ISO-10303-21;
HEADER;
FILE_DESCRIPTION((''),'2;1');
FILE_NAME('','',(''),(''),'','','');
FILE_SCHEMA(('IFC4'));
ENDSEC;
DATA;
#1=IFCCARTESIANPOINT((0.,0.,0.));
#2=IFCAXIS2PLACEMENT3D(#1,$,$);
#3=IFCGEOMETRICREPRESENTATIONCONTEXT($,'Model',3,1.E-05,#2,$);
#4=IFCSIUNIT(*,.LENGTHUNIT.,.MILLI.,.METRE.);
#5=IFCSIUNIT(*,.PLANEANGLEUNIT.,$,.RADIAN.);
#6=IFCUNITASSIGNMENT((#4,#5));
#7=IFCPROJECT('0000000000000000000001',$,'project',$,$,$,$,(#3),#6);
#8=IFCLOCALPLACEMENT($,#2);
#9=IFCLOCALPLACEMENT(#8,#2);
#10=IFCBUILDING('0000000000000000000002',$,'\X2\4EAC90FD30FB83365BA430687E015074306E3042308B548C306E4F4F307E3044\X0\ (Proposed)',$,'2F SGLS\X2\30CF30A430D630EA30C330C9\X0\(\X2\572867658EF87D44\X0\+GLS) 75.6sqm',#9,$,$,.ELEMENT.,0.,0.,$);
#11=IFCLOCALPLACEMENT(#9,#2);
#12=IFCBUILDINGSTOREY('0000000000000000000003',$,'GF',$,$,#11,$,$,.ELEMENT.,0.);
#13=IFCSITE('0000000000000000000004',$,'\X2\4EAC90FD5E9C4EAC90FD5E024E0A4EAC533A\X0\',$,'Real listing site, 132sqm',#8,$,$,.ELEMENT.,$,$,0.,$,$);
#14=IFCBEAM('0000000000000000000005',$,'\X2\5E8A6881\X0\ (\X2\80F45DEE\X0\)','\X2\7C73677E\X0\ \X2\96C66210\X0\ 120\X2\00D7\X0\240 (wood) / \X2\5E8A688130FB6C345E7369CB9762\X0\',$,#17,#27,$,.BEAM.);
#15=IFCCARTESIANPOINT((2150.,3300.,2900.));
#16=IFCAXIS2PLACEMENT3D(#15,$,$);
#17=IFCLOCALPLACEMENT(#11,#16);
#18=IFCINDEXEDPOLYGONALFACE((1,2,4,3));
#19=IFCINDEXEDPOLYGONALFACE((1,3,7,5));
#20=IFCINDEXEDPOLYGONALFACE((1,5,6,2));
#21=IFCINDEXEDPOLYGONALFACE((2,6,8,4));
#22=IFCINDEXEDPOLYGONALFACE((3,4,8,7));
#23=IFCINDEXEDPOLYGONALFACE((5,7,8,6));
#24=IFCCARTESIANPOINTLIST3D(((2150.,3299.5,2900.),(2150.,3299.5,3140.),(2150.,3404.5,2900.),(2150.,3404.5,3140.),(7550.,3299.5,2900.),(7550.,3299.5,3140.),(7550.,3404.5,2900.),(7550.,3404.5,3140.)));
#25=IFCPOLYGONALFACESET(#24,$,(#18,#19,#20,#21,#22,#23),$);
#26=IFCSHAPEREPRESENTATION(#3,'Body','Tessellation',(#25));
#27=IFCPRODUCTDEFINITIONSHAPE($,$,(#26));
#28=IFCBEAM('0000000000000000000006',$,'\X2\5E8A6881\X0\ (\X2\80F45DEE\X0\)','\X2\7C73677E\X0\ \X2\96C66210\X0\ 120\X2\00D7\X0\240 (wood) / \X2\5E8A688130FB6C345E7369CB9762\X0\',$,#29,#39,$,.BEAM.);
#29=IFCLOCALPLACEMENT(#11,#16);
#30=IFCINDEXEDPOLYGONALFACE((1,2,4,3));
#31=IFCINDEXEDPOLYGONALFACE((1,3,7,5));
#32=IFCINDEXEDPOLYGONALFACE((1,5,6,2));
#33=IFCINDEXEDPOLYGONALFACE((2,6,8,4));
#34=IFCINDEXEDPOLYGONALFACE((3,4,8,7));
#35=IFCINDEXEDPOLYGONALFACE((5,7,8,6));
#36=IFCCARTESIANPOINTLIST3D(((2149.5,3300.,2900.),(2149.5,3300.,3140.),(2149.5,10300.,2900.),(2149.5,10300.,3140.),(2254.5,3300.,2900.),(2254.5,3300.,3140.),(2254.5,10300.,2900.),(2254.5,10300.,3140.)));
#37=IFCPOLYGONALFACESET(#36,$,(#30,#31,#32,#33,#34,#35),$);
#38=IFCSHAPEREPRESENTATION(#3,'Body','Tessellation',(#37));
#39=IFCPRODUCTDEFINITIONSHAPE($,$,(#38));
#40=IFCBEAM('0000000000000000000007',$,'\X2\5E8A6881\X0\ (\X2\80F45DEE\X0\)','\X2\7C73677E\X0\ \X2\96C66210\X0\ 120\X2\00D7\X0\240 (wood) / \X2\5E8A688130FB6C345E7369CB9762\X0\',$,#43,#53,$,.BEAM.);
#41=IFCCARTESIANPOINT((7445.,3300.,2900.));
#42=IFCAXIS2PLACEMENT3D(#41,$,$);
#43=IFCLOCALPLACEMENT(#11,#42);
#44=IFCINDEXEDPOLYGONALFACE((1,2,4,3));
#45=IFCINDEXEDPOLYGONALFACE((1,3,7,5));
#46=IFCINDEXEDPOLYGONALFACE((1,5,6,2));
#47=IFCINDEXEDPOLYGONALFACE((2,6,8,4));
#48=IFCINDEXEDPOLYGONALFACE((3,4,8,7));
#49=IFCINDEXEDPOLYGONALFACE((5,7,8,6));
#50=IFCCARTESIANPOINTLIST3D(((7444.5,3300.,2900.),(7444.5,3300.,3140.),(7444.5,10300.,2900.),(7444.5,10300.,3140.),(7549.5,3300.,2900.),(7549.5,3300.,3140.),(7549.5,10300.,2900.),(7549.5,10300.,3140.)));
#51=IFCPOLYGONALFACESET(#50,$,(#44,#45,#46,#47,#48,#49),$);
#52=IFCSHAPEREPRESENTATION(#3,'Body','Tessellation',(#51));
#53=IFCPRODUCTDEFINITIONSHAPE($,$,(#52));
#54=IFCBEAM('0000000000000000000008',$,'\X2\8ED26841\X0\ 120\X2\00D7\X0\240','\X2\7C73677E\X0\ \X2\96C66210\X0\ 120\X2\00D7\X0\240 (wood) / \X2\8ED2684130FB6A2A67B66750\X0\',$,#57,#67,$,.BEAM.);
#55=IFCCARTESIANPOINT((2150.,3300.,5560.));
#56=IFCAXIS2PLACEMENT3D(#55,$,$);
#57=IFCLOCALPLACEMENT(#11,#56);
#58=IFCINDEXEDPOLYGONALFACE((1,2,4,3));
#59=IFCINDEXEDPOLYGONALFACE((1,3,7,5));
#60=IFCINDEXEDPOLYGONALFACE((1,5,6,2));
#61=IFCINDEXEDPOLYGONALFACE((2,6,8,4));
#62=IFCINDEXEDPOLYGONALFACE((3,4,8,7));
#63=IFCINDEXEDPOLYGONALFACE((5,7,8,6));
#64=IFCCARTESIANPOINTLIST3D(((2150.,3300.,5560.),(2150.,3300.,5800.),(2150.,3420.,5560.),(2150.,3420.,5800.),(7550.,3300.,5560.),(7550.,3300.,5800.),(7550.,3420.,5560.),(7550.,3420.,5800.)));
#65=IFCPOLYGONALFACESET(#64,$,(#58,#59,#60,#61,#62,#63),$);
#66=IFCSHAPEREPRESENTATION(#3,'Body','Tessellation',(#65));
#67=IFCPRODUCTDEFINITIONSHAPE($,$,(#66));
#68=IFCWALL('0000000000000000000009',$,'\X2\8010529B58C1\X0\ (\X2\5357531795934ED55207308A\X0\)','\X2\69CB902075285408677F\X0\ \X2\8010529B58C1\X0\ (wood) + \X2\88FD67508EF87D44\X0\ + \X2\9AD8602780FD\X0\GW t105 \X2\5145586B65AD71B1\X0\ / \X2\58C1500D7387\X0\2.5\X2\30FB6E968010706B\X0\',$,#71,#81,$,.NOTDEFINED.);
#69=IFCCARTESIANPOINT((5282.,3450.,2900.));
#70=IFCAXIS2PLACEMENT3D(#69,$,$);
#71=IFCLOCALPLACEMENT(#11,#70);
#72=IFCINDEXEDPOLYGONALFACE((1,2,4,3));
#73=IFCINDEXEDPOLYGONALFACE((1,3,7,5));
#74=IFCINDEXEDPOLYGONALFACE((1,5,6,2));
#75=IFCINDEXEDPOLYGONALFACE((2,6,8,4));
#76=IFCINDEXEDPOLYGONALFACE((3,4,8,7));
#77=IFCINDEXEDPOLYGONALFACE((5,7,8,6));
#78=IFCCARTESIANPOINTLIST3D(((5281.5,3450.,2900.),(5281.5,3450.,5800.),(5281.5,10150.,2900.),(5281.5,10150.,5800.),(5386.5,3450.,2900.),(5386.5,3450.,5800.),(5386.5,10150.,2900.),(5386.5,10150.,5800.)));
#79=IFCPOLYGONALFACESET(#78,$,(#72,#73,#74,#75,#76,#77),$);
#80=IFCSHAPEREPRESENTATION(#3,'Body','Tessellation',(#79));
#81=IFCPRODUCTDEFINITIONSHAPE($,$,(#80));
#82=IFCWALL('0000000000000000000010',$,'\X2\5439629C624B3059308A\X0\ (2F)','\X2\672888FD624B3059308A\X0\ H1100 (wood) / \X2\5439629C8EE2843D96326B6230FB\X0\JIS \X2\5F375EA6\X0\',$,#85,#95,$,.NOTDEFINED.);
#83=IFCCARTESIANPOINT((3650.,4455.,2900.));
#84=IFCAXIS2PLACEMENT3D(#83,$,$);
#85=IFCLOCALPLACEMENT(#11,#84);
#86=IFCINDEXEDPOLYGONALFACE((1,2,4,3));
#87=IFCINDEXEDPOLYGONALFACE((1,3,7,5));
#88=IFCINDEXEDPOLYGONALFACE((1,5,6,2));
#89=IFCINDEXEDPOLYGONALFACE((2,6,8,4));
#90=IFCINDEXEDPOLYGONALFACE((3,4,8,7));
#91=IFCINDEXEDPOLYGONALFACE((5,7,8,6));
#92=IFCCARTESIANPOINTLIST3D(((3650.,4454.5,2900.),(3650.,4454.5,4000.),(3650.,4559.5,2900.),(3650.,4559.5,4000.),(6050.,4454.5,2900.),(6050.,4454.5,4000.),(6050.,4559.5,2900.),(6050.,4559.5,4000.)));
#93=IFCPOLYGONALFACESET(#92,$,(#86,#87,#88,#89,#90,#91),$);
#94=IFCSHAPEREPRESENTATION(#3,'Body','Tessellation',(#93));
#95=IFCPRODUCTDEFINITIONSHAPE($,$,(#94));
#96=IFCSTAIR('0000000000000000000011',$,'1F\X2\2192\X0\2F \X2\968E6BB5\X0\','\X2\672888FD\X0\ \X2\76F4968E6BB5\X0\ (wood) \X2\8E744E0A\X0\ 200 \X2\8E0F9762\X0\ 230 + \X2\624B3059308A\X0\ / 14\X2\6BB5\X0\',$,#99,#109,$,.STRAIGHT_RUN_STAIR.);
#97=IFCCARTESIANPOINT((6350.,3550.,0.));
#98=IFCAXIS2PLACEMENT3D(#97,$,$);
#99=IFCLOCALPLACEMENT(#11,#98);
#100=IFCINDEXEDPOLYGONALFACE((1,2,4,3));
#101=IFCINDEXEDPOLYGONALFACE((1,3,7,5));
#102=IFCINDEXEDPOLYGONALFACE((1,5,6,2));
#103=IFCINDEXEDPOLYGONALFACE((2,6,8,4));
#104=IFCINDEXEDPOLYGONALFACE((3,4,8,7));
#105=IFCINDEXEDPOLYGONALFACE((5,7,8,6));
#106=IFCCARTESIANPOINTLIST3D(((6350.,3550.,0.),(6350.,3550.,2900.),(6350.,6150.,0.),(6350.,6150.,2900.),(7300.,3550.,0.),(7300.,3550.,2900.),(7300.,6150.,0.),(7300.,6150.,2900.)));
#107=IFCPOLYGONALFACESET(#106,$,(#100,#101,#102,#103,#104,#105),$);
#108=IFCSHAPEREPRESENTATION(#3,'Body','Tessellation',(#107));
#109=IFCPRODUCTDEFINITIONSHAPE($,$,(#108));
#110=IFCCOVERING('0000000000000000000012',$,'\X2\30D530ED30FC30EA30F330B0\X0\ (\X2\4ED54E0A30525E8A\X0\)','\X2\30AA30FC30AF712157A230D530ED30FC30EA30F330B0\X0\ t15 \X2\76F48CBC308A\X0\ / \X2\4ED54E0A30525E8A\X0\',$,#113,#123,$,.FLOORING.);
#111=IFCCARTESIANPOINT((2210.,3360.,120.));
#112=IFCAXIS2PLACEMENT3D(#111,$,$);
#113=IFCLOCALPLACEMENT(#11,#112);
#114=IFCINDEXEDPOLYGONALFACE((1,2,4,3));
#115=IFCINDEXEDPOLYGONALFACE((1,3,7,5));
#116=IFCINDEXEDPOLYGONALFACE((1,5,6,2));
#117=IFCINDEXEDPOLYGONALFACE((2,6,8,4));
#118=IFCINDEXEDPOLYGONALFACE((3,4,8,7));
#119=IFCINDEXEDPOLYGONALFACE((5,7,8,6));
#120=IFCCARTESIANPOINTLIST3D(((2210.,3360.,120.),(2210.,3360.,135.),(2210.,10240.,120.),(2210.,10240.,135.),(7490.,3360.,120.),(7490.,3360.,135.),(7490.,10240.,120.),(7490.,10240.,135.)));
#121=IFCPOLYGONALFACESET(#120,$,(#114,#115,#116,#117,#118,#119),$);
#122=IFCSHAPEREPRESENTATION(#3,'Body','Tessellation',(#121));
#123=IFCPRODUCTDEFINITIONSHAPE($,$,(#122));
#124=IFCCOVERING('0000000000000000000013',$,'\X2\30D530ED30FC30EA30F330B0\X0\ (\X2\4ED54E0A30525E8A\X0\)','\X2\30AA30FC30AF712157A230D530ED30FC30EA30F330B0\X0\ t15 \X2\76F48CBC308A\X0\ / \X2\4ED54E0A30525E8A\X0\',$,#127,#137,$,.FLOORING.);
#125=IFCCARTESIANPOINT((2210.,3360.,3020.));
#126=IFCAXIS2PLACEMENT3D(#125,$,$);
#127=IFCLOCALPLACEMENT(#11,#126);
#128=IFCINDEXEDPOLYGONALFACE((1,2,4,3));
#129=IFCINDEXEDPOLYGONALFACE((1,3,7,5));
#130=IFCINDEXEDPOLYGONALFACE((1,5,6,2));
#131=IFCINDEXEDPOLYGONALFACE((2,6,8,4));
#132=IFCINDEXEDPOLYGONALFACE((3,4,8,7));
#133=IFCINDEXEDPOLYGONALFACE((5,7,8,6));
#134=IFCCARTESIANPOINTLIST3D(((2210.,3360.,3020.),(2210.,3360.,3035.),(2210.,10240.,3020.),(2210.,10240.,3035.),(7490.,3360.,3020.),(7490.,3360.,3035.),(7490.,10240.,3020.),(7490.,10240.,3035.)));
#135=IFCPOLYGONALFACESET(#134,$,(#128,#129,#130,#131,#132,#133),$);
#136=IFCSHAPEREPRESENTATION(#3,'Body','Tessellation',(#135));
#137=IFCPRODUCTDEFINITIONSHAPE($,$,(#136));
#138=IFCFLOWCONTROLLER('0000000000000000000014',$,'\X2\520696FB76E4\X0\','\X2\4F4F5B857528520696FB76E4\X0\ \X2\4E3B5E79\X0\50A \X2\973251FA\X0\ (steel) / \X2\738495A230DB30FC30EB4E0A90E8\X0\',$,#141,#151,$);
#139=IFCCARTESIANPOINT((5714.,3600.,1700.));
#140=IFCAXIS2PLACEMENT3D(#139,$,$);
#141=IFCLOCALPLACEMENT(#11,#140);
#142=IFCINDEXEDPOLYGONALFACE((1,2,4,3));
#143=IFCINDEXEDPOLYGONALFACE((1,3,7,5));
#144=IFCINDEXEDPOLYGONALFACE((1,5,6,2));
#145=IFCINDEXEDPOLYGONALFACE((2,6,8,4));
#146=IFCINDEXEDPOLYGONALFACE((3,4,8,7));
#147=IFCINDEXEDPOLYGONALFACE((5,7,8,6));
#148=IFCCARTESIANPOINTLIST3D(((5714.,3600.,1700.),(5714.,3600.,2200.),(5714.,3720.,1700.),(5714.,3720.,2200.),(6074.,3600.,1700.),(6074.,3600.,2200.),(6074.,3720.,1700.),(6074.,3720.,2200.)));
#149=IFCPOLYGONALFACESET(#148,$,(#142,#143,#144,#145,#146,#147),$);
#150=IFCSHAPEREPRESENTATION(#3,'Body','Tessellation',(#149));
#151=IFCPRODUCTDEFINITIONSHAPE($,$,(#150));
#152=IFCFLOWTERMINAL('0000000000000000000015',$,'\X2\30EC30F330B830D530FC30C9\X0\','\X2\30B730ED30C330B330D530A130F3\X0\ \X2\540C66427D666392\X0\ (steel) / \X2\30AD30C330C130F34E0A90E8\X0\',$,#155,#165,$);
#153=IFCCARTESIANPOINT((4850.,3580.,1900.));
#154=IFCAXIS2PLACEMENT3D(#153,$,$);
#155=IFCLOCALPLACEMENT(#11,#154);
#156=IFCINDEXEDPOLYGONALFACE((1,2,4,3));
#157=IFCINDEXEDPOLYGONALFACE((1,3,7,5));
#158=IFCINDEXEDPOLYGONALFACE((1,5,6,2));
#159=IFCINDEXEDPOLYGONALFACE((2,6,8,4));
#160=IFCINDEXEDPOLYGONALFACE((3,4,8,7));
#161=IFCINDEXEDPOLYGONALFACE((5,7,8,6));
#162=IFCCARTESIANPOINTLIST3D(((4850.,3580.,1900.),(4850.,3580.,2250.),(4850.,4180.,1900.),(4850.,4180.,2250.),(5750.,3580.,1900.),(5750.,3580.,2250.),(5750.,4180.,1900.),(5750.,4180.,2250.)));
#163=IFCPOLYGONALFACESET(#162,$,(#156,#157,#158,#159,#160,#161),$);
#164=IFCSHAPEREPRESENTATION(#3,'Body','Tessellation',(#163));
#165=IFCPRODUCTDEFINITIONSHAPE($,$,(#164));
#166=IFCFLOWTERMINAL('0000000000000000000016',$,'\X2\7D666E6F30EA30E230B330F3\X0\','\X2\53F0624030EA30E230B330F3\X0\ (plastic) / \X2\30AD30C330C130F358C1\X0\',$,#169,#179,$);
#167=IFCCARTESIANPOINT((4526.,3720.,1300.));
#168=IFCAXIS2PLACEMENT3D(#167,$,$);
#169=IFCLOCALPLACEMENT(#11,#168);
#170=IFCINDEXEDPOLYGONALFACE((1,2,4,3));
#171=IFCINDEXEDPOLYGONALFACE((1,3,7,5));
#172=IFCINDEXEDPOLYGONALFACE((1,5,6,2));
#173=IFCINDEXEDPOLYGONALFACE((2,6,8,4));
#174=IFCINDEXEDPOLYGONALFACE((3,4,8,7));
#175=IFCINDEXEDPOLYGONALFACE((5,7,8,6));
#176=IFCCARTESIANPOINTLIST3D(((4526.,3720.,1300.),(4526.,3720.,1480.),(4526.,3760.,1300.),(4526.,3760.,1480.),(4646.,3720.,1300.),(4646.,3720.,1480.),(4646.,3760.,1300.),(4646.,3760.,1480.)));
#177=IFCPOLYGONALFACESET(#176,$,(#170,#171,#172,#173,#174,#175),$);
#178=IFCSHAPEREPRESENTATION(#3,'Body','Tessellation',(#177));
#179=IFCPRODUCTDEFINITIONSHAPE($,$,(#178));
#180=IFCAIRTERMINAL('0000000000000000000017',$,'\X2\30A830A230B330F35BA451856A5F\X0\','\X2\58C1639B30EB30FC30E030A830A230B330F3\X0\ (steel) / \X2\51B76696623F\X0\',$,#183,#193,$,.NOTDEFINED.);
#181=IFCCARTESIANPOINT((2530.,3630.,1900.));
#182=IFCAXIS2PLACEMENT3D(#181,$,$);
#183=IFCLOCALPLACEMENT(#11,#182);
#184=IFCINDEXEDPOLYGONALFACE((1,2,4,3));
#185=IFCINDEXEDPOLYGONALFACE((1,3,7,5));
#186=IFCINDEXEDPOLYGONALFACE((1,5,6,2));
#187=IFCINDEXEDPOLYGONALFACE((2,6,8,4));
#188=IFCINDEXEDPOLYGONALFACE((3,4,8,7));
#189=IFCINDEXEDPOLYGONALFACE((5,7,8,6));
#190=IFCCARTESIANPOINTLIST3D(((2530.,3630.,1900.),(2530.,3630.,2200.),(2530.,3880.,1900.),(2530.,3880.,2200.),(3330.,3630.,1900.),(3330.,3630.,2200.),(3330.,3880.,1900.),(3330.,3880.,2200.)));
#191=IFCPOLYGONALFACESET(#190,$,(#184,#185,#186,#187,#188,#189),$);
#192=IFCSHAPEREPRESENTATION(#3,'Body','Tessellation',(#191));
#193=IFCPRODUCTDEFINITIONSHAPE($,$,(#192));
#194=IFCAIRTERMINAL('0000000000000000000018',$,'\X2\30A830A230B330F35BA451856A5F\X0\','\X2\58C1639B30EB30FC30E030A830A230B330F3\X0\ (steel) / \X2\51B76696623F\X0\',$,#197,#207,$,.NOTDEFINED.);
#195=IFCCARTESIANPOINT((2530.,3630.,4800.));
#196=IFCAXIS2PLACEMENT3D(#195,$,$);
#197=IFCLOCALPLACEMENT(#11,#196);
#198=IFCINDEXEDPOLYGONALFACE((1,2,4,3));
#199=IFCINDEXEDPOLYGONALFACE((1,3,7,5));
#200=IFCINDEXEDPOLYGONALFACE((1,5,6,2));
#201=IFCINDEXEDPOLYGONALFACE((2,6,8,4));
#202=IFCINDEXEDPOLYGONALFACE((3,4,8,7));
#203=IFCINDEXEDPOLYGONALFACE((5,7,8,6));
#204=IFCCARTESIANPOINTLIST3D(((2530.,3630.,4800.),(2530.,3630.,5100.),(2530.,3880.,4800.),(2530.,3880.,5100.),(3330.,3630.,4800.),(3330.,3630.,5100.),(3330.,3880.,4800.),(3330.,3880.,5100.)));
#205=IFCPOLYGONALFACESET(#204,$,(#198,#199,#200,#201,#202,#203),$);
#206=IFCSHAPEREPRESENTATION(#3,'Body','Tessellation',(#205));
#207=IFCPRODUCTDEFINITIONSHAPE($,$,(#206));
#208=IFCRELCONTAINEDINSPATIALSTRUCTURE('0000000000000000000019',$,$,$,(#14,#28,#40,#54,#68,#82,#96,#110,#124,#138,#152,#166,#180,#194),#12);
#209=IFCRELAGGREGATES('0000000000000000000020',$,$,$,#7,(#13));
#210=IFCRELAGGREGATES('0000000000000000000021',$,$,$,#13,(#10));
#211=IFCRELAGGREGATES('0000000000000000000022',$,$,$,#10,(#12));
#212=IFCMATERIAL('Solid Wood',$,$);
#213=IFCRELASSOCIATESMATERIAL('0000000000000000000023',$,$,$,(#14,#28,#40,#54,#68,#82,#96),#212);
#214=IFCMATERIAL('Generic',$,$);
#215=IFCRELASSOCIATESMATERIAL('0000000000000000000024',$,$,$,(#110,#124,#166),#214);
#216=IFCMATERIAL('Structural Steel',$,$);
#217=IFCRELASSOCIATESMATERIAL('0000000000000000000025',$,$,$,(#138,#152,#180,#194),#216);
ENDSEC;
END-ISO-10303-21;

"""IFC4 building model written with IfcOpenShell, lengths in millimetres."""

from ifc_helpers import new_model, si_unit, frame, frame_2d, origin, place, context, project, spatial, rectangle, extrude, material, element, save


model = new_model("IFC4")

# Units and contexts
model_context = context("Model", 3, precision=1e-05, world=origin())
ifc_project = project(units=[si_unit("LENGTHUNIT", "METRE", prefix="MILLI"), si_unit("PLANEANGLEUNIT", "RADIAN")], contexts=[model_context])

# Site, building, storey
site_placement = place(None, origin())
site = spatial("IfcSite", under=ifc_project, at=site_placement, Name="京都府京都市上京区", ObjectType="Real listing site, 132sqm", CompositionType="ELEMENT", RefElevation=0.0)
building_placement = place(site_placement, origin())
building = spatial("IfcBuilding", under=site, at=building_placement, Name="京都・茶室と縁側のある和の住まい (Proposed)", ObjectType="2F SGLSハイブリッド(在来軸組+GLS) 75.6sqm", CompositionType="ELEMENT", ElevationOfRefHeight=0.0, ElevationOfTerrain=0.0)
storey_placement = place(building_placement, origin())
storey = spatial("IfcBuildingStorey", under=building, at=storey_placement, Name="GF", CompositionType="ELEMENT", Elevation=0.0)

# Shared definitions
ifc_material_1 = material(Name="Solid Wood")

# Beams
beam_1_placement = place(storey_placement, frame((2150.0, 3300.0, 2900.0)))
element("IfcBeam", 1, at=beam_1_placement, inside=storey, material=ifc_material_1, Name="床梁 (胴差)", Description="米松 集成 120×240 (wood) / 床梁・水平構面", PredefinedType="BEAM", context=model_context, shape_type="SweptSolid", body=[
    extrude(rectangle(XDim=5400.0, YDim=105.0, at=frame_2d((2700.0, 52.0))), frame((2150.0, 3300.0, 2900.0)), (0.0, 0.0, 1.0), 240.0),
])
beam_2_placement = place(storey_placement, frame((2150.0, 3300.0, 2900.0)))
element("IfcBeam", 2, at=beam_2_placement, inside=storey, material=ifc_material_1, Name="床梁 (胴差)", Description="米松 集成 120×240 (wood) / 床梁・水平構面", PredefinedType="BEAM", context=model_context, shape_type="SweptSolid", body=[
    extrude(rectangle(XDim=105.0, YDim=7000.0, at=frame_2d((52.0, 3500.0))), frame((2150.0, 3300.0, 2900.0)), (0.0, 0.0, 1.0), 240.0),
])
beam_3_placement = place(storey_placement, frame((7445.0, 3300.0, 2900.0)))
element("IfcBeam", 3, at=beam_3_placement, inside=storey, material=ifc_material_1, Name="床梁 (胴差)", Description="米松 集成 120×240 (wood) / 床梁・水平構面", PredefinedType="BEAM", context=model_context, shape_type="SweptSolid", body=[
    extrude(rectangle(XDim=105.0, YDim=7000.0, at=frame_2d((52.0, 3500.0))), frame((7445.0, 3300.0, 2900.0)), (0.0, 0.0, 1.0), 240.0),
])
beam_4_placement = place(storey_placement, frame((2150.0, 3300.0, 5560.0)))
element("IfcBeam", 4, at=beam_4_placement, inside=storey, material=ifc_material_1, Name="軒桁 120×240", Description="米松 集成 120×240 (wood) / 軒桁・横架材", PredefinedType="BEAM", context=model_context, shape_type="SweptSolid", body=[
    extrude(rectangle(XDim=5400.0, YDim=120.0, at=frame_2d((2700.0, 60.0))), frame((2150.0, 3300.0, 5560.0)), (0.0, 0.0, 1.0), 240.0),
])

# Walls
wall_1_placement = place(storey_placement, frame((5282.0, 3450.0, 2900.0)))
element("IfcWall", 5, at=wall_1_placement, inside=storey, material=ifc_material_1, Name="耐力壁 (南北間仕切り)", Description="構造用合板 耐力壁 (wood) + 製材軸組 + 高性能GW t105 充填断熱 / 壁倍率2.5・準耐火", PredefinedType="NOTDEFINED", context=model_context, shape_type="SweptSolid", body=[
    extrude(rectangle(XDim=105.0, YDim=6700.0, at=frame_2d((52.0, 3350.0))), frame((5282.0, 3450.0, 2900.0)), (0.0, 0.0, 1.0), 2900.0),
])
wall_2_placement = place(storey_placement, frame((3650.0, 4455.0, 2900.0)))
element("IfcWall", 6, at=wall_2_placement, inside=storey, material=ifc_material_1, Name="吹抜手すり (2F)", Description="木製手すり H1100 (wood) / 吹抜転落防止・JIS 強度", PredefinedType="NOTDEFINED", context=model_context, shape_type="SweptSolid", body=[
    extrude(rectangle(XDim=2400.0, YDim=105.0, at=frame_2d((1200.0, 52.0))), frame((3650.0, 4455.0, 2900.0)), (0.0, 0.0, 1.0), 1100.0),
])

# Stair
stair_placement = place(storey_placement, frame((6350.0, 3550.0, 0.0)))
element("IfcStair", 7, at=stair_placement, inside=storey, material=ifc_material_1, Name="1F→2F 階段", Description="木製 直階段 (wood) 蹴上 200 踏面 230 + 手すり / 14段", PredefinedType="STRAIGHT_RUN_STAIR", context=model_context, shape_type="SweptSolid", body=[
    extrude(rectangle(XDim=950.0, YDim=2600.0, at=frame_2d((475.0, 1300.0))), frame((6350.0, 3550.0, 0.0)), (0.0, 0.0, 1.0), 2900.0),
])

# Coverings
ifc_material_2 = material(Name="Generic")
covering_1_placement = place(storey_placement, frame((2210.0, 3360.0, 120.0)))
element("IfcCovering", 8, at=covering_1_placement, inside=storey, material=ifc_material_2, Name="フローリング (仕上げ床)", Description="オーク無垢フローリング t15 直貼り / 仕上げ床", PredefinedType="FLOORING", context=model_context, shape_type="SweptSolid", body=[
    extrude(rectangle(XDim=5280.0, YDim=6880.0, at=frame_2d((2640.0, 3440.0))), frame((2210.0, 3360.0, 120.0)), (0.0, 0.0, 1.0), 15.0),
])
covering_2_placement = place(storey_placement, frame((2210.0, 3360.0, 3020.0)))
element("IfcCovering", 9, at=covering_2_placement, inside=storey, material=ifc_material_2, Name="フローリング (仕上げ床)", Description="オーク無垢フローリング t15 直貼り / 仕上げ床", PredefinedType="FLOORING", context=model_context, shape_type="SweptSolid", body=[
    extrude(rectangle(XDim=5280.0, YDim=6880.0, at=frame_2d((2640.0, 3440.0))), frame((2210.0, 3360.0, 3020.0)), (0.0, 0.0, 1.0), 15.0),
])

# Flow controller
ifc_material_3 = material(Name="Structural Steel")
flow_controller_placement = place(storey_placement, frame((5714.0, 3600.0, 1700.0)))
element("IfcFlowController", 10, at=flow_controller_placement, inside=storey, material=ifc_material_3, Name="分電盤", Description="住宅用分電盤 主幹50A 露出 (steel) / 玄関ホール上部", context=model_context, shape_type="SweptSolid", body=[
    extrude(rectangle(XDim=360.0, YDim=120.0, at=frame_2d((180.0, 60.0))), frame((5714.0, 3600.0, 1700.0)), (0.0, 0.0, 1.0), 500.0),
])

# Flow terminals
flow_terminal_1_placement = place(storey_placement, frame((4850.0, 3580.0, 1900.0)))
element("IfcFlowTerminal", 11, at=flow_terminal_1_placement, inside=storey, material=ifc_material_3, Name="レンジフード", Description="シロッコファン 同時給排 (steel) / キッチン上部", context=model_context, shape_type="SweptSolid", body=[
    extrude(rectangle(XDim=900.0, YDim=600.0, at=frame_2d((450.0, 300.0))), frame((4850.0, 3580.0, 1900.0)), (0.0, 0.0, 1.0), 350.0),
])
flow_terminal_2_placement = place(storey_placement, frame((4526.0, 3720.0, 1300.0)))
element("IfcFlowTerminal", 12, at=flow_terminal_2_placement, inside=storey, material=ifc_material_2, Name="給湯リモコン", Description="台所リモコン (plastic) / キッチン壁", context=model_context, shape_type="SweptSolid", body=[
    extrude(rectangle(XDim=120.0, YDim=40.0, at=frame_2d((60.0, 20.0))), frame((4526.0, 3720.0, 1300.0)), (0.0, 0.0, 1.0), 180.0),
])

# Air terminals
air_terminal_1_placement = place(storey_placement, frame((2530.0, 3630.0, 1900.0)))
element("IfcAirTerminal", 13, at=air_terminal_1_placement, inside=storey, material=ifc_material_3, Name="エアコン室内機", Description="壁掛ルームエアコン (steel) / 冷暖房", PredefinedType="NOTDEFINED", context=model_context, shape_type="SweptSolid", body=[
    extrude(rectangle(XDim=800.0, YDim=250.0, at=frame_2d((400.0, 125.0))), frame((2530.0, 3630.0, 1900.0)), (0.0, 0.0, 1.0), 300.0),
])
air_terminal_2_placement = place(storey_placement, frame((2530.0, 3630.0, 4800.0)))
element("IfcAirTerminal", 14, at=air_terminal_2_placement, inside=storey, material=ifc_material_3, Name="エアコン室内機", Description="壁掛ルームエアコン (steel) / 冷暖房", PredefinedType="NOTDEFINED", context=model_context, shape_type="SweptSolid", body=[
    extrude(rectangle(XDim=800.0, YDim=250.0, at=frame_2d((400.0, 125.0))), frame((2530.0, 3630.0, 4800.0)), (0.0, 0.0, 1.0), 300.0),
])

save(model, "model.ifc")
